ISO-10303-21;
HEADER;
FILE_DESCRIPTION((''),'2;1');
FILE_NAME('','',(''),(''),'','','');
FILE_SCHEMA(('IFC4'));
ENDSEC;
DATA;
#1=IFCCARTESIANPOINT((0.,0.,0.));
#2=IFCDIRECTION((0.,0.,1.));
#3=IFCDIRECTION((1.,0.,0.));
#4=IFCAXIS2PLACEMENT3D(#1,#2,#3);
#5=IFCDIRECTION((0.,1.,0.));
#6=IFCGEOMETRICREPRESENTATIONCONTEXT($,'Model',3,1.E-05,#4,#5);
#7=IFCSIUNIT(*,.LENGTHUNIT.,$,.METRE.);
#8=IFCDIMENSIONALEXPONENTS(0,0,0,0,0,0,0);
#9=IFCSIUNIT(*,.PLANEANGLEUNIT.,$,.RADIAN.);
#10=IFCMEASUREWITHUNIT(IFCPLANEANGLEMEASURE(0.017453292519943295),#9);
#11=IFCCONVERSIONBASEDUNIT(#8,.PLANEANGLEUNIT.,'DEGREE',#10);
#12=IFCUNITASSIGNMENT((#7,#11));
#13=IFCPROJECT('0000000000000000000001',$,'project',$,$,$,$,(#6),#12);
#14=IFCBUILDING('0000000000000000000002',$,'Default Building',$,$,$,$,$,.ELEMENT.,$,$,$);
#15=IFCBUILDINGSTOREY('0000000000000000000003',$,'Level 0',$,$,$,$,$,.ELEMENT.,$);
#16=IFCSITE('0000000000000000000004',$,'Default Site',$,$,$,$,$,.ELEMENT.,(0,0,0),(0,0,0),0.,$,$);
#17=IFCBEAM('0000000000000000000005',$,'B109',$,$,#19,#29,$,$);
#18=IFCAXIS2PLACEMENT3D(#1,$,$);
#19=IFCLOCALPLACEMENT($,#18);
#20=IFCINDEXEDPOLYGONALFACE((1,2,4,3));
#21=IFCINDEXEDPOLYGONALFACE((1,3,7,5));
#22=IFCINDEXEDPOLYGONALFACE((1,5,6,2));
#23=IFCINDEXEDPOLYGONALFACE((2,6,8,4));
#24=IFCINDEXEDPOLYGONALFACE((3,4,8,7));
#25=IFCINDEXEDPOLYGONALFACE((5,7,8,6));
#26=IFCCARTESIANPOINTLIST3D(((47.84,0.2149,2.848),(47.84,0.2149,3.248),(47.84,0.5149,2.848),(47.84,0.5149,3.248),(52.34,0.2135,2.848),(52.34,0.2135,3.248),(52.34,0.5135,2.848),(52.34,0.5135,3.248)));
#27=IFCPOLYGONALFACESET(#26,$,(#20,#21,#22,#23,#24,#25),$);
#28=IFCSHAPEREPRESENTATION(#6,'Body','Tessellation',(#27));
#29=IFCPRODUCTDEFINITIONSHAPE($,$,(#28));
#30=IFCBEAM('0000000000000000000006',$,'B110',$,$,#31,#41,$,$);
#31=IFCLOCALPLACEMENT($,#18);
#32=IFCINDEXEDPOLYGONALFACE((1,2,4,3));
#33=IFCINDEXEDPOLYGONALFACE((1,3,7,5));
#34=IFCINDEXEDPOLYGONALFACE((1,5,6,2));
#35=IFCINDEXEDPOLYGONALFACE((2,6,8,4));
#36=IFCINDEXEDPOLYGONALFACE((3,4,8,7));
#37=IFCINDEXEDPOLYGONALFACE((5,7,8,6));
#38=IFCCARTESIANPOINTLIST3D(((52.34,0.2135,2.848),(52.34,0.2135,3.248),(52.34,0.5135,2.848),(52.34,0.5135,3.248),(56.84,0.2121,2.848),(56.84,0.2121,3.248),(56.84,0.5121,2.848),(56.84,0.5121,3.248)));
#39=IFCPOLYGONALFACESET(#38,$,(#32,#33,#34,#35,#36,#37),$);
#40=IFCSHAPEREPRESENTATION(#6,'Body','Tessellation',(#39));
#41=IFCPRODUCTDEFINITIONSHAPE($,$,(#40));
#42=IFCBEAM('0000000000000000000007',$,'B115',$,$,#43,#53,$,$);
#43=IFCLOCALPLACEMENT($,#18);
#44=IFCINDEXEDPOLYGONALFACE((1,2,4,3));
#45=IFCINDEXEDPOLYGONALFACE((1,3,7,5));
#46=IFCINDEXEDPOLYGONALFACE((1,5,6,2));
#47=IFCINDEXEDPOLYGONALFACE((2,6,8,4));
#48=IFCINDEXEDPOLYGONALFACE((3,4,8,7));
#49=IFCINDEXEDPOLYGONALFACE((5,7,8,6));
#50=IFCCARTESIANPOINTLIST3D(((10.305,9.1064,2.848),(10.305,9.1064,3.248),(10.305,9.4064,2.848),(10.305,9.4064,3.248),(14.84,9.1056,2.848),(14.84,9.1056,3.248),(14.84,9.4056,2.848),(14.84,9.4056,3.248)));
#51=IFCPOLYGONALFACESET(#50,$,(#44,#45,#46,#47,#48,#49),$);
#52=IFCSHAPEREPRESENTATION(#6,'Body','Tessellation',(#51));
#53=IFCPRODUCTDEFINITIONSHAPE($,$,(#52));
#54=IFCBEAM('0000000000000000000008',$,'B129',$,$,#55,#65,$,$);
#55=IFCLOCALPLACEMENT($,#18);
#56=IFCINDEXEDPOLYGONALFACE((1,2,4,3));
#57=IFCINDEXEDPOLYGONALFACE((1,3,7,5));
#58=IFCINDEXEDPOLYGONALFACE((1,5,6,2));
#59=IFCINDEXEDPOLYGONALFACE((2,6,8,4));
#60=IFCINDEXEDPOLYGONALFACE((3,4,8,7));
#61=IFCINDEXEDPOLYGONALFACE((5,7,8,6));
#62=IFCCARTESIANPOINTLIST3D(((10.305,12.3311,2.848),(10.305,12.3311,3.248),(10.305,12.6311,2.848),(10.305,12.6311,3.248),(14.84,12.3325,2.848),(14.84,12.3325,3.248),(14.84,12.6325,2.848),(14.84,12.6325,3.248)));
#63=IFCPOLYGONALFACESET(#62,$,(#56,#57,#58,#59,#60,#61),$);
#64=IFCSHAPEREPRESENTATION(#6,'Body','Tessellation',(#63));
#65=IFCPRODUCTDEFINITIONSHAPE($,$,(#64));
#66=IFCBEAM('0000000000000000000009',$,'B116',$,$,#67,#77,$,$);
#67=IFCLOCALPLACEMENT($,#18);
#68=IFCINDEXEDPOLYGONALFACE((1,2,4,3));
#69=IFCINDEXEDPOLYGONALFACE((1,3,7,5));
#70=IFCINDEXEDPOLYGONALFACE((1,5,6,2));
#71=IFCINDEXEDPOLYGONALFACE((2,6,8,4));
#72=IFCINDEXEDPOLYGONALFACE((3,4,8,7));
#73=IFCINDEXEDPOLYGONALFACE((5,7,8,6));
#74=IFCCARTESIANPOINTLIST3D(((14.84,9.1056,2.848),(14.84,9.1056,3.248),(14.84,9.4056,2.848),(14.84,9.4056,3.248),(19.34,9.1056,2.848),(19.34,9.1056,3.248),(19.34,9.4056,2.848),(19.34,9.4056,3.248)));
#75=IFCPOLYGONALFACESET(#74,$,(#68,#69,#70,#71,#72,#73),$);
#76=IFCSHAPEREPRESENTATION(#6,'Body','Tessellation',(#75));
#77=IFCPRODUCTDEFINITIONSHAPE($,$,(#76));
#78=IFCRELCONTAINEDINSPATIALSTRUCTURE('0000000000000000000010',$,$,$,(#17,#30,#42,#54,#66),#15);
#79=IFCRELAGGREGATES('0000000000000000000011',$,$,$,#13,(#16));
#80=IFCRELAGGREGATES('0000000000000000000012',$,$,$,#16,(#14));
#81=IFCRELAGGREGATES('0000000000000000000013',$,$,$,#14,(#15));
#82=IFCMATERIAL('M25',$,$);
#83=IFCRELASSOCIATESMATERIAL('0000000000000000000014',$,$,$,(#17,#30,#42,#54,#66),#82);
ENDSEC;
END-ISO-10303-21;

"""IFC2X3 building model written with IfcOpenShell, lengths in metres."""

from ifc_helpers import new_model, entity, si_unit, converted_unit, direction, frame, frame_2d, origin_with_axes, place, context, project, spatial, rectangle, extrude, material, element, save


model = new_model("IFC2X3")

# Units and contexts
model_context = context("Model", 3, precision=1e-05, world=origin_with_axes(), true_north=direction((0.0, 1.0, 0.0)))
ifc_project = project(units=[si_unit("LENGTHUNIT", "METRE"), converted_unit("PLANEANGLEUNIT", "DEGREE", entity("IfcPlaneAngleMeasure", 0.017453292519943295), si_unit("PLANEANGLEUNIT", "RADIAN"), dimensions=[0, 0, 0, 0, 0, 0, 0])], contexts=[model_context])

# Site, building, storey
site = spatial("IfcSite", under=ifc_project, Name="Default Site", CompositionType="ELEMENT", RefLatitude=(0, 0, 0), RefLongitude=(0, 0, 0), RefElevation=0.0)
building = spatial("IfcBuilding", under=site, Name="Default Building", CompositionType="ELEMENT")
storey = spatial("IfcBuildingStorey", under=building, Name="Level 0", CompositionType="ELEMENT")

# Shared definitions
ifc_material = material(Name="M25")
placement = place(None, origin_with_axes())

# Beams
element("IfcBeam", 1, at=placement, inside=storey, material=ifc_material, Name="B109", context=model_context, shape_type="SweptSolid", body=[
    extrude(rectangle(XDim=0.3, YDim=0.4, at=frame_2d((0.0, 0.0), x_axis=(0.0, 1.0, 0.0))), frame((47.84, 0.3649, 3.048), z_axis=(1.0, -0.000297, 0.0), x_axis=(0.0, 0.0, -1.0)), (0.0, 0.0, 1.0), 4.5),
])
element("IfcBeam", 2, at=placement, inside=storey, material=ifc_material, Name="B110", context=model_context, shape_type="SweptSolid", body=[
    extrude(rectangle(XDim=0.3, YDim=0.4, at=frame_2d((0.0, 0.0), x_axis=(0.0, 1.0, 0.0))), frame((52.34, 0.3635, 3.048), z_axis=(1.0, -0.000311, 0.0), x_axis=(0.0, 0.0, -1.0)), (0.0, 0.0, 1.0), 4.5),
])
element("IfcBeam", 3, at=placement, inside=storey, material=ifc_material, Name="B115", context=model_context, shape_type="SweptSolid", body=[
    extrude(rectangle(XDim=0.3, YDim=0.4, at=frame_2d((0.0, 0.0), x_axis=(0.0, 1.0, 0.0))), frame((10.305, 9.2564, 3.048), z_axis=(1.0, -0.000182, 0.0), x_axis=(0.0, 0.0, -1.0)), (0.0, 0.0, 1.0), 4.535),
])
element("IfcBeam", 4, at=placement, inside=storey, material=ifc_material, Name="B129", context=model_context, shape_type="SweptSolid", body=[
    extrude(rectangle(XDim=0.3, YDim=0.4, at=frame_2d((0.0, 0.0), x_axis=(0.0, 1.0, 0.0))), frame((10.305, 12.4811, 3.048), z_axis=(1.0, 0.000301, 0.0), x_axis=(0.0, 0.0, -1.0)), (0.0, 0.0, 1.0), 4.535),
])
element("IfcBeam", 5, at=placement, inside=storey, material=ifc_material, Name="B116", context=model_context, shape_type="SweptSolid", body=[
    extrude(rectangle(XDim=0.3, YDim=0.4, at=frame_2d((0.0, 0.0), x_axis=(0.0, 1.0, 0.0))), frame((14.84, 9.2556, 3.048), z_axis=(1.0, 0.000013, 0.0), x_axis=(0.0, 0.0, -1.0)), (0.0, 0.0, 1.0), 4.5),
])

save(model, "model.ifc")
